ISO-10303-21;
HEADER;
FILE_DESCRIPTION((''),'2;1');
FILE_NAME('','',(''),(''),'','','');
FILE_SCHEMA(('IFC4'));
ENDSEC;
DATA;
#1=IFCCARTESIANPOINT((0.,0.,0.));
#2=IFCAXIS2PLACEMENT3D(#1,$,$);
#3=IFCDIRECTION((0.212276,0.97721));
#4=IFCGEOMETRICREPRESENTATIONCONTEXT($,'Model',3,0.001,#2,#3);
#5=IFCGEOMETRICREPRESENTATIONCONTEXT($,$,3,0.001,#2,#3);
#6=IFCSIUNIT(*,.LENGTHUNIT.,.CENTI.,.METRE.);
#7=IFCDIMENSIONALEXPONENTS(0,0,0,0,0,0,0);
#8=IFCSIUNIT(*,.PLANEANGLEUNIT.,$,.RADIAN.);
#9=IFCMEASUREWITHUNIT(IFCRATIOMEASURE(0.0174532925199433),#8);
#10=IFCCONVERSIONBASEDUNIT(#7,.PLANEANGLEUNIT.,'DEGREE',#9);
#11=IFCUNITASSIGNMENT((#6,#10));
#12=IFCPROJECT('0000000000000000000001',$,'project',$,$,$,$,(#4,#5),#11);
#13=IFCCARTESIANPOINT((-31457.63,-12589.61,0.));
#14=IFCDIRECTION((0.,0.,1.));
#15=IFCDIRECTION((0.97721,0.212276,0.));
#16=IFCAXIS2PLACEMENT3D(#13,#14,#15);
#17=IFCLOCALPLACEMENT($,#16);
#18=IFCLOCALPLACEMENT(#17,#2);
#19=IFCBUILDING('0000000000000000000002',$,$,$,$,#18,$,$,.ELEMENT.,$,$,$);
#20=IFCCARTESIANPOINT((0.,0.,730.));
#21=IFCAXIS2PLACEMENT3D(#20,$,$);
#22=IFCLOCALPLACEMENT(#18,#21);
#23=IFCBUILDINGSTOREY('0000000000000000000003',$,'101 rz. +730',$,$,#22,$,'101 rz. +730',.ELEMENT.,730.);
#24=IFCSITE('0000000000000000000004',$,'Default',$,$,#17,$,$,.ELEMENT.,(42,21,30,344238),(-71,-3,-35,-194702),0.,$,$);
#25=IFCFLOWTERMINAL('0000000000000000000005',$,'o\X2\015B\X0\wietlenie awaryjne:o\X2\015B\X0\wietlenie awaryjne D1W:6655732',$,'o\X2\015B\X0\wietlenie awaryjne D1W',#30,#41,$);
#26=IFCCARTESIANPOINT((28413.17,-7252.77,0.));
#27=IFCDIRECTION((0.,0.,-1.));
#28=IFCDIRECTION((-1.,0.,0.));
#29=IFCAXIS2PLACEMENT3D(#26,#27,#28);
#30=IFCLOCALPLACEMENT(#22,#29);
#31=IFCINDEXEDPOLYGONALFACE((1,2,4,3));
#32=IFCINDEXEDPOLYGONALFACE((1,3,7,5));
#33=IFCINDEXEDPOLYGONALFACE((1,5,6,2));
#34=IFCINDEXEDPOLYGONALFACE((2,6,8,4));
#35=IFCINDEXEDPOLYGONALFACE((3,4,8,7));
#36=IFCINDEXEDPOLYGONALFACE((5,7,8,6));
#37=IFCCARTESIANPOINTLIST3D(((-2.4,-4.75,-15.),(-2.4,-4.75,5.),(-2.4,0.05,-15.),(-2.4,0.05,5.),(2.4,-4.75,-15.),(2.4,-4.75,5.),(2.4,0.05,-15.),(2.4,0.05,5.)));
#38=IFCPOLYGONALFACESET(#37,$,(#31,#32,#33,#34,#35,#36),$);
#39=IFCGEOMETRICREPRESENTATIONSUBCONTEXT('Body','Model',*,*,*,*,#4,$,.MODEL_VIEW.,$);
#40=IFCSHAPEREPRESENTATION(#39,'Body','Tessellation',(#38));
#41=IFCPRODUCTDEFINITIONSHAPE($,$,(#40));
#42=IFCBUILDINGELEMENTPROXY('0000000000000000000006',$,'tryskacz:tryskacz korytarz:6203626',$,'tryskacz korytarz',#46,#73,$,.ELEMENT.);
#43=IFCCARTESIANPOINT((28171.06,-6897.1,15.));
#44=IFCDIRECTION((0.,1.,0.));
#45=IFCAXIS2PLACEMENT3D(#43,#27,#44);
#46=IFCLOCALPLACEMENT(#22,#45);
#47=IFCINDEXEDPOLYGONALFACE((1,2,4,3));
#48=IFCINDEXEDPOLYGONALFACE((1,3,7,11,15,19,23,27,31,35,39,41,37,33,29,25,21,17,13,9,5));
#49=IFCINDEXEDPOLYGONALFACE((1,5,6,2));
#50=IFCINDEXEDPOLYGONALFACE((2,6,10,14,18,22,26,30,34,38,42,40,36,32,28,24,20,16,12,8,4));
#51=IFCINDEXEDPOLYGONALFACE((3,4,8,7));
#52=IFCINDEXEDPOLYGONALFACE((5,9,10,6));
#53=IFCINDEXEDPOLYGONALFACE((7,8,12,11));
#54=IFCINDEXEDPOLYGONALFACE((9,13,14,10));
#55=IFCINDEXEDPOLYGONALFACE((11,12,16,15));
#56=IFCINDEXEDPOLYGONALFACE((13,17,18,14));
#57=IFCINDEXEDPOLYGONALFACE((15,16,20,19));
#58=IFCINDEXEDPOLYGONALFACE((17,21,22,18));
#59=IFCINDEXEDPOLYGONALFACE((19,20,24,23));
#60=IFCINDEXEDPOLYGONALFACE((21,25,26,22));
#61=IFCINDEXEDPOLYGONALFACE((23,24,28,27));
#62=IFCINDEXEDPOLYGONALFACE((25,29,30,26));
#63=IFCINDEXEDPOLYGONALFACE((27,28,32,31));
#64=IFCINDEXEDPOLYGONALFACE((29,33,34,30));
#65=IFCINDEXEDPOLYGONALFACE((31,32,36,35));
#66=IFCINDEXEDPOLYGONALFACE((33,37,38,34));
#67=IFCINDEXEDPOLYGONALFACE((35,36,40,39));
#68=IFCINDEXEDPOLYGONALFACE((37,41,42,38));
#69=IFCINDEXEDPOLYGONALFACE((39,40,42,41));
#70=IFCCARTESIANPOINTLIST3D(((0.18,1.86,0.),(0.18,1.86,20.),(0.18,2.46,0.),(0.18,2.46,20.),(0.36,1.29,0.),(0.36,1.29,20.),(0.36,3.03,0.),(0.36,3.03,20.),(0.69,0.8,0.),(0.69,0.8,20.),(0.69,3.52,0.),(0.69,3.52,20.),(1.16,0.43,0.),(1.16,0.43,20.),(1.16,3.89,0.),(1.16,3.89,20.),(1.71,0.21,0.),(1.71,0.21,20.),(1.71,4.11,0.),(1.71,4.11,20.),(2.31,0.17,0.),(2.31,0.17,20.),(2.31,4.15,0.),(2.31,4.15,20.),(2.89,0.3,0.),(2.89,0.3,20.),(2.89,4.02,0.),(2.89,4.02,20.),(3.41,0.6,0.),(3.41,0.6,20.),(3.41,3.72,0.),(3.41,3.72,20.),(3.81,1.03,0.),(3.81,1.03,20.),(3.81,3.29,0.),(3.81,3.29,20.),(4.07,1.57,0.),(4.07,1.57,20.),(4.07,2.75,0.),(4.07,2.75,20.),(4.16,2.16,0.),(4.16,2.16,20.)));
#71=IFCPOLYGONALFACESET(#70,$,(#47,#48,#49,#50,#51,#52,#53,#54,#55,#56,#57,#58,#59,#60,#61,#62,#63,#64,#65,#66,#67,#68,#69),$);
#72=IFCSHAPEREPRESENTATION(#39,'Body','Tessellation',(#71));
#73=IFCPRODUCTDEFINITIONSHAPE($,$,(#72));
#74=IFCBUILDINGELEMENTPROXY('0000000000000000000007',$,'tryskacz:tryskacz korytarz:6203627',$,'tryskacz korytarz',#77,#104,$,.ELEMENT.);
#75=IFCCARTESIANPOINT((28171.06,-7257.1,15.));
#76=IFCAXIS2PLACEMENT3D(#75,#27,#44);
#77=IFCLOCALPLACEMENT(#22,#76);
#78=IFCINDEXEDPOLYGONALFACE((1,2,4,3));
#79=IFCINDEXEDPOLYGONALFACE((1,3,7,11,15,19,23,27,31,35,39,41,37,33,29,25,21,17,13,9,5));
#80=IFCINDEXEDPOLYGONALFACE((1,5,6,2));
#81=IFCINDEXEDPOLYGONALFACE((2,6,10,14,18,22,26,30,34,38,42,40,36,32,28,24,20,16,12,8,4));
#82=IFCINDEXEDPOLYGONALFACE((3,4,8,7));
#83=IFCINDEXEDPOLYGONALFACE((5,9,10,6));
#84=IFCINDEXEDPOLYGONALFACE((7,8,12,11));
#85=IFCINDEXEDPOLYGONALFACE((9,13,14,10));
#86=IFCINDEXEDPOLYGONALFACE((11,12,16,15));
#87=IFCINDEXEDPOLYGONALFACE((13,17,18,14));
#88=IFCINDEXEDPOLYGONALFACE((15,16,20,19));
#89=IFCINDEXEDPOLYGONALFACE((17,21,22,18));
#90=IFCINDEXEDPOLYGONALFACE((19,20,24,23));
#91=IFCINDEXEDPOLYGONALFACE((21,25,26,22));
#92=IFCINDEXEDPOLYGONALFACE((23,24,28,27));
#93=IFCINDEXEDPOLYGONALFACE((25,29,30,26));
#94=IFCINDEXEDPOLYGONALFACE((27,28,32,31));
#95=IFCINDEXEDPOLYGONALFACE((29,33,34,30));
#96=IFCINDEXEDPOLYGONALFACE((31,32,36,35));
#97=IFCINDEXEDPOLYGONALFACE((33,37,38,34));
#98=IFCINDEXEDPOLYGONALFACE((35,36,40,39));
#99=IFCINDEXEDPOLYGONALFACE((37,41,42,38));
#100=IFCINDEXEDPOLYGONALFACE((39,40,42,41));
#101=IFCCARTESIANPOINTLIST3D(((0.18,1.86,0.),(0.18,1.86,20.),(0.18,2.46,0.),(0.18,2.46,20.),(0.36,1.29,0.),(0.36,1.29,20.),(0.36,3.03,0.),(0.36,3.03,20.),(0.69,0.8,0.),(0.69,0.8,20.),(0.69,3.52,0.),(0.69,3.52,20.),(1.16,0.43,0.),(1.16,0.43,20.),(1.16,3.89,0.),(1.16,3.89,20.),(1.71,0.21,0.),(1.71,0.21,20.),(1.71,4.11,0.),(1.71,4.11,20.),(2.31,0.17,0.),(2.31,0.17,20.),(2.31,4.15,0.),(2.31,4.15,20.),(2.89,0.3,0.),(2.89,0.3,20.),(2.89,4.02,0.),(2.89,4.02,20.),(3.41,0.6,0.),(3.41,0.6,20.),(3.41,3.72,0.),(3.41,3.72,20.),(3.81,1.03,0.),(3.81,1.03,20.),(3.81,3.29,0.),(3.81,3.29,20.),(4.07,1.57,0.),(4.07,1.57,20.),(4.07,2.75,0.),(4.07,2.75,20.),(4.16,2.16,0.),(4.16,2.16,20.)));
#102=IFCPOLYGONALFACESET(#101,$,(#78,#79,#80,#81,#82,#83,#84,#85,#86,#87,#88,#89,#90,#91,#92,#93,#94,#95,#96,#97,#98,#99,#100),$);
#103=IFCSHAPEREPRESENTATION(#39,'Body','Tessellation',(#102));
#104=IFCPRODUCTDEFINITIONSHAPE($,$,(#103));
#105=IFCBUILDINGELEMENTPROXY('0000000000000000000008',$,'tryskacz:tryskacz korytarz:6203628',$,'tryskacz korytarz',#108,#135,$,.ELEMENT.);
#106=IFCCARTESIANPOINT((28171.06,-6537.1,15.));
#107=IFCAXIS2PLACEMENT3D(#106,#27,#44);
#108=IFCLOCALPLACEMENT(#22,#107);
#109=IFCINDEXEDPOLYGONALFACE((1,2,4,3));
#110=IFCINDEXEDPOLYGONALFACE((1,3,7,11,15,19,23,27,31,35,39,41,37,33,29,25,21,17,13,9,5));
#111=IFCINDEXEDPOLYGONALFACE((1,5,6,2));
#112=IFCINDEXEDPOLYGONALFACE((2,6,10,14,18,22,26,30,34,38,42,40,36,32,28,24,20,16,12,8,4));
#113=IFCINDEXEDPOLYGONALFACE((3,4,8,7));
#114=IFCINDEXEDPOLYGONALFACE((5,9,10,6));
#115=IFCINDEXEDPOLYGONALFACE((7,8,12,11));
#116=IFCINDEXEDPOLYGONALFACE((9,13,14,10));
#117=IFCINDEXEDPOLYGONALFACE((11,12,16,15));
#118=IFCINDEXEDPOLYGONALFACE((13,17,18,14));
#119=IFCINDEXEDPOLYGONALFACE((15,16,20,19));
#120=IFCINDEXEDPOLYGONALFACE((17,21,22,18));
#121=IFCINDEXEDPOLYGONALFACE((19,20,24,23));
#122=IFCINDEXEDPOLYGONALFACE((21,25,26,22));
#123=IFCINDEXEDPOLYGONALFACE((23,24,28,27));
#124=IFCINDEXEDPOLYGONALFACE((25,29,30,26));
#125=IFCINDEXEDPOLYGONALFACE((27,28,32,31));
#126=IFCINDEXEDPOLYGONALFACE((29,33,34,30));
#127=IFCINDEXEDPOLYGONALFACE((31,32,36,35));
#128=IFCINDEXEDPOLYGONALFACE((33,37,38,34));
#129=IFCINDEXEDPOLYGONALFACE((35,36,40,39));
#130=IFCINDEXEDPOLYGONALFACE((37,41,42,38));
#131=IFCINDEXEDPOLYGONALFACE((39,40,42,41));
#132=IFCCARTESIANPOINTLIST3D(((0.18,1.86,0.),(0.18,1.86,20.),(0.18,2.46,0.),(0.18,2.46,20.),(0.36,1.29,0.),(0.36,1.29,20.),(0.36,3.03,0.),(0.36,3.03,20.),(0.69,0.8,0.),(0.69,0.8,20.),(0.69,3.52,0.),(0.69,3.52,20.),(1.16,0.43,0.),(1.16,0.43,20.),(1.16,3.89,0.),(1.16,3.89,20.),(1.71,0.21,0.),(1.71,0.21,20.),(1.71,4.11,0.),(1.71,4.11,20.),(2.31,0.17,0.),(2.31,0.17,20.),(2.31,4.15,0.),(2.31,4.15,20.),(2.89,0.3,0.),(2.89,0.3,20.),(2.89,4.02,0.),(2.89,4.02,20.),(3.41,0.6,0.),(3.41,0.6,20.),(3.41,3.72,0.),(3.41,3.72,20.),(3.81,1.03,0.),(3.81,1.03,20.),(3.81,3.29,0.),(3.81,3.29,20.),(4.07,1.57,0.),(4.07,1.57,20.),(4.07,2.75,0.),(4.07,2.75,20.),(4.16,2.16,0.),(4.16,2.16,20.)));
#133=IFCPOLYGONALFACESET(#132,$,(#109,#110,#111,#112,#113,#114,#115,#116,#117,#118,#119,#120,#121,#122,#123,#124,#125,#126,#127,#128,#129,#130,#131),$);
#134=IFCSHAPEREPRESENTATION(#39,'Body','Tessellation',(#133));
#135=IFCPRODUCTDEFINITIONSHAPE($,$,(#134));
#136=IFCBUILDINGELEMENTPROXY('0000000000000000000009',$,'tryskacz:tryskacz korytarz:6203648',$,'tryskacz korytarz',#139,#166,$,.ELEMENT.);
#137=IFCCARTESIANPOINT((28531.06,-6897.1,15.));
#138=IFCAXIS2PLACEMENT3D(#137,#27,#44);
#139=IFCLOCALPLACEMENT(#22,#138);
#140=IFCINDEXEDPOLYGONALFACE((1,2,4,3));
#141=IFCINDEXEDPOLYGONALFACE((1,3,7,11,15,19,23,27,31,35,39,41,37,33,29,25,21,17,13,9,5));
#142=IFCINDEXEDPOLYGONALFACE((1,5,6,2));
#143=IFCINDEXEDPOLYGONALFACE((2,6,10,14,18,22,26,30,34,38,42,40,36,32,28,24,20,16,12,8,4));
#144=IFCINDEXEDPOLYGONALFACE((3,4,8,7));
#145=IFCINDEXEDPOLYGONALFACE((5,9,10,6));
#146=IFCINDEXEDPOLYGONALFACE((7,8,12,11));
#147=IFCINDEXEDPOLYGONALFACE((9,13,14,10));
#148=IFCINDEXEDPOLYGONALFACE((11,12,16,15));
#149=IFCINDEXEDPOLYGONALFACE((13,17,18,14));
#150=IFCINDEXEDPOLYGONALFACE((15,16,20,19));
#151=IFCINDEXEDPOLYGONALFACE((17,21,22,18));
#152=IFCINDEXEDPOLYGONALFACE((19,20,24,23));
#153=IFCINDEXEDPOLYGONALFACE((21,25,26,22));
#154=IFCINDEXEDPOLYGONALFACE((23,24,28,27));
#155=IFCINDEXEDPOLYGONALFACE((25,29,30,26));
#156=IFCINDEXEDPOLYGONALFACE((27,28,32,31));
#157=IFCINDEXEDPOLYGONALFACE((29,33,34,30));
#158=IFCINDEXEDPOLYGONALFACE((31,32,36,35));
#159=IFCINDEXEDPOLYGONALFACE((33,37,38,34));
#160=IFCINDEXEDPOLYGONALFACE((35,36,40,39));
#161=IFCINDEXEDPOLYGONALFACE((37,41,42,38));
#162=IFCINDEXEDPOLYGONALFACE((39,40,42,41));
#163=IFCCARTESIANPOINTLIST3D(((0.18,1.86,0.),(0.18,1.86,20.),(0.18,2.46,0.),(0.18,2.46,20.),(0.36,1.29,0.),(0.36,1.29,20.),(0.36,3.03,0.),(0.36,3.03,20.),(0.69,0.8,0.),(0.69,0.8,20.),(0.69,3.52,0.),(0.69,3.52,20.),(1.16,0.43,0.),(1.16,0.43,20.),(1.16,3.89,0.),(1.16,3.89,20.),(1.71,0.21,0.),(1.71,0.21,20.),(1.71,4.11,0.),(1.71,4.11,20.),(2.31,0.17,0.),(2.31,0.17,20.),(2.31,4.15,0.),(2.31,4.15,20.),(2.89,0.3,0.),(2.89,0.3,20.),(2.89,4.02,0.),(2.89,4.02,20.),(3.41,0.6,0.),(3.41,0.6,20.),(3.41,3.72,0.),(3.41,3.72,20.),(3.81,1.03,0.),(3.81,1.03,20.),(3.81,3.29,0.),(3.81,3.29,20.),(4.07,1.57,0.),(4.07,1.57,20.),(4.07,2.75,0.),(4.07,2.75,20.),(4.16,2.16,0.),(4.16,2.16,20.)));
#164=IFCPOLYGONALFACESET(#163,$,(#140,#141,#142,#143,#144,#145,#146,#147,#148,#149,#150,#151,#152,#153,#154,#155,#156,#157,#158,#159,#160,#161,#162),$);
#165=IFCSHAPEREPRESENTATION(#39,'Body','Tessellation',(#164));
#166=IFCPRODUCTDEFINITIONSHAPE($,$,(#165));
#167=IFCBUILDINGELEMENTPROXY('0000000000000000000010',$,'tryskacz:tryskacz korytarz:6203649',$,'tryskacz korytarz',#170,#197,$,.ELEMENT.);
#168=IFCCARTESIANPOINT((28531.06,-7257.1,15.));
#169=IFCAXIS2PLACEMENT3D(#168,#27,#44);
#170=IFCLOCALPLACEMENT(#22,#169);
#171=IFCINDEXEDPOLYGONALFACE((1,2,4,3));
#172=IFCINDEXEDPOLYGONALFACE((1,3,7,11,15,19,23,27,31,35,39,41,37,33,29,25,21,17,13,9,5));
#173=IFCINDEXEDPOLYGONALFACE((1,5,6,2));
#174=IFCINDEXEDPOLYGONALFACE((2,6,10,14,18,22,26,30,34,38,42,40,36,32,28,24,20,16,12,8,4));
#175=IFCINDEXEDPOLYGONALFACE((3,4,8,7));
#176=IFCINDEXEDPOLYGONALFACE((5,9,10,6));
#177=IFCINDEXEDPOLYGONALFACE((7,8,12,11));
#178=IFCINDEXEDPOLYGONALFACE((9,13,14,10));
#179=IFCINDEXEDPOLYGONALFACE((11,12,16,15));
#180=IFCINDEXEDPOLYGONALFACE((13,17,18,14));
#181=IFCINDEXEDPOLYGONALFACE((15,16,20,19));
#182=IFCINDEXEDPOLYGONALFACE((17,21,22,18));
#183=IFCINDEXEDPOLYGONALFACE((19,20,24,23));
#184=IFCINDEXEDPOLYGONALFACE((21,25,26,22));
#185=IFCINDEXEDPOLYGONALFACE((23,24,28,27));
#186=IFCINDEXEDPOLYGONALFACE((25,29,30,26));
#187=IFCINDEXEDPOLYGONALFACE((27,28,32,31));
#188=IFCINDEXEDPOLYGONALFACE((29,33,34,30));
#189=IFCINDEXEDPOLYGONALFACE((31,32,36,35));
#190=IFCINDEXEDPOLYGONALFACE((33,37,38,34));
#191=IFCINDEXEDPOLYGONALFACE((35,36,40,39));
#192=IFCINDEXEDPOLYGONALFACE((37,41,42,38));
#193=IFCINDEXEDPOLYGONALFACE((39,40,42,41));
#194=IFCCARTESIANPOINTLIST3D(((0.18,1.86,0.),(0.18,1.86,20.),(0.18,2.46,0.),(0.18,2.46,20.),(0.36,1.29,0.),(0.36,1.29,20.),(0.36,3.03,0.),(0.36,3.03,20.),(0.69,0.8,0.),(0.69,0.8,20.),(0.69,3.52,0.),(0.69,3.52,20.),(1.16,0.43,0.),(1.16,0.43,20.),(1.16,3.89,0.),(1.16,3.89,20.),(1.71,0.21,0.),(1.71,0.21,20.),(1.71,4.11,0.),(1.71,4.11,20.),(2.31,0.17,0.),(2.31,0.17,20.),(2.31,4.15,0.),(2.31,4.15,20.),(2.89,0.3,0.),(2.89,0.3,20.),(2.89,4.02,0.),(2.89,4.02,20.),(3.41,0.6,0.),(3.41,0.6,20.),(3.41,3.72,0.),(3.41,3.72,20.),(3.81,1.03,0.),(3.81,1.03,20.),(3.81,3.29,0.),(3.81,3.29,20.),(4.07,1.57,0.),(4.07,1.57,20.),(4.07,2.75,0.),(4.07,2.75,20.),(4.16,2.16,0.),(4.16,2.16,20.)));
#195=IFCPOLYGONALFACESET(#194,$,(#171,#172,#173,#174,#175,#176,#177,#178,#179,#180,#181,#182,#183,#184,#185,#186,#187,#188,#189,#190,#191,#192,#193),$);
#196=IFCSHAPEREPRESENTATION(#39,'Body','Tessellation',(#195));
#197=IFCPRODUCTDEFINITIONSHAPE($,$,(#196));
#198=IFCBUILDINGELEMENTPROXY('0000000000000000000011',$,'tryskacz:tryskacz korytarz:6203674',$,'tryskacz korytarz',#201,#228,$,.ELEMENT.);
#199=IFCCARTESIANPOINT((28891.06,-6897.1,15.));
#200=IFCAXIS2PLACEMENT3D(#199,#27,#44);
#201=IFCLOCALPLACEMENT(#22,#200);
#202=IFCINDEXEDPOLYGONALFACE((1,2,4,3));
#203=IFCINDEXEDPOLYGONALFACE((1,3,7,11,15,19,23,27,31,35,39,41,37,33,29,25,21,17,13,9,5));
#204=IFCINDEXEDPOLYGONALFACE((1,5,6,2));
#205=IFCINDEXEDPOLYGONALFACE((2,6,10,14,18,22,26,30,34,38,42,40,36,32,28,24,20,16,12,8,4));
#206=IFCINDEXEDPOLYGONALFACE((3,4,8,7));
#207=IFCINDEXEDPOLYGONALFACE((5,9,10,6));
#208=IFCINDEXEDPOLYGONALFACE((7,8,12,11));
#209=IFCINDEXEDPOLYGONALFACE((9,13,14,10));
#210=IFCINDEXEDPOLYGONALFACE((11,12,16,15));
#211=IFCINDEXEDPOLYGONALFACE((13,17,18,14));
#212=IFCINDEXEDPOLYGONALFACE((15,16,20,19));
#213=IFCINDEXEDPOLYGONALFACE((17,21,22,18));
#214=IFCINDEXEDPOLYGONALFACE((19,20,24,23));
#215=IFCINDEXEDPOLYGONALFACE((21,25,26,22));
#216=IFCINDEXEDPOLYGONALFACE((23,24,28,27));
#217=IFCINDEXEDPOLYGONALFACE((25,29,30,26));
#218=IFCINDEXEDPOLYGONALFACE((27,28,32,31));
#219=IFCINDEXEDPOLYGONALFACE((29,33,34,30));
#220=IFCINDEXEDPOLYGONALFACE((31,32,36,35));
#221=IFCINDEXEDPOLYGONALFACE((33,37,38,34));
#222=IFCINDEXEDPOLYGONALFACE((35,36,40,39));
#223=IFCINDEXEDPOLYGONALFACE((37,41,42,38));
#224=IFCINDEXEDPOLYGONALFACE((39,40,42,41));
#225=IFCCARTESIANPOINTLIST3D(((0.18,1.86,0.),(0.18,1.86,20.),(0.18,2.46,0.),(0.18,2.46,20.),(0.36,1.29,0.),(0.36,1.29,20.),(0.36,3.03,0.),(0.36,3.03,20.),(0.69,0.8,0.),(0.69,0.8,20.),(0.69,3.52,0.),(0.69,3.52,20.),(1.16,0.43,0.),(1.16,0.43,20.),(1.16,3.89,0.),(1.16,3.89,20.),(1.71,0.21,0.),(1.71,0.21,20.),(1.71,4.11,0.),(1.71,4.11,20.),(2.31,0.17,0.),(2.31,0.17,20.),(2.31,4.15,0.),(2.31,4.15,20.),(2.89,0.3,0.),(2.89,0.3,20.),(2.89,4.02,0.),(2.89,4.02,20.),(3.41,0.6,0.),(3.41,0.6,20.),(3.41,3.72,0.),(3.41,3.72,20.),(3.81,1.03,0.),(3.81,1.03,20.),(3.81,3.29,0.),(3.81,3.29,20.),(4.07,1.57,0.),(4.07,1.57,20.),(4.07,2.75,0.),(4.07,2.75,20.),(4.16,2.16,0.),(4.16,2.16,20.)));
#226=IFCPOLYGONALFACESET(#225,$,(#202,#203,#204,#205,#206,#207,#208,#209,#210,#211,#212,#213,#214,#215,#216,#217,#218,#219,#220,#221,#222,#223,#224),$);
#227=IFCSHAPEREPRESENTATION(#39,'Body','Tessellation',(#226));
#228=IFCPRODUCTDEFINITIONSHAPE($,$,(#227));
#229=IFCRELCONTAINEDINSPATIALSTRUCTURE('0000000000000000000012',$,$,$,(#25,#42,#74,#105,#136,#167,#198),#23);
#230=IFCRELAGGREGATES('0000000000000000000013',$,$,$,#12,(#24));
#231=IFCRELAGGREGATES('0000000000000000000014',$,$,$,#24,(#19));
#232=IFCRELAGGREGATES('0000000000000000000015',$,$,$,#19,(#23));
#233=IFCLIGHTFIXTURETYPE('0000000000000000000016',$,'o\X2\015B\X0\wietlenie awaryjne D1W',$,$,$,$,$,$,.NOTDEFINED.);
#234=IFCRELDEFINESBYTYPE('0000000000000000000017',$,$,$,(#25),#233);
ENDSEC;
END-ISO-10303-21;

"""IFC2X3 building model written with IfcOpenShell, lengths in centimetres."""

from ifc_helpers import new_model, entity, si_unit, converted_unit, direction, frame, frame_2d, origin, place, context, subcontext, project, spatial, rectangle, circle, extrude, source, transform, mapped, type_object, type_shapes, element, save


model = new_model("IFC2X3")

# Units and contexts
model_context = context("Model", 3, precision=0.001, world=origin(), true_north=direction((0.212276, 0.97721)))
context_of_model = context(None, 3, precision=0.001, world=origin(), true_north=direction((0.212276, 0.97721)))
body_context = subcontext(model_context, "Body", "Model", "MODEL_VIEW")
ifc_project = project(units=[si_unit("LENGTHUNIT", "METRE", prefix="CENTI"), converted_unit("PLANEANGLEUNIT", "DEGREE", entity("IfcRatioMeasure", 0.0174532925199433), si_unit("PLANEANGLEUNIT", "RADIAN"), dimensions=[0, 0, 0, 0, 0, 0, 0])], contexts=[model_context, context_of_model])

# Site, building, storey
site_placement = place(None, frame((-31457.63, -12589.61, 0.0), z_axis=(0.0, 0.0, 1.0), x_axis=(0.97721, 0.212276, 0.0)))
site = spatial("IfcSite", under=ifc_project, at=site_placement, Name="Default", CompositionType="ELEMENT", RefLatitude=(42, 21, 30, 344238), RefLongitude=(-71, -3, -35, -194702), RefElevation=0.0)
building_placement = place(site_placement, origin())
building = spatial("IfcBuilding", under=site, at=building_placement, CompositionType="ELEMENT")
storey_placement = place(building_placement, frame((0.0, 0.0, 730.0)))
storey = spatial("IfcBuildingStorey", under=building, at=storey_placement, Name="101 rz. +730", LongName="101 rz. +730", CompositionType="ELEMENT", Elevation=730.0)

# Flow terminal
light_fixture_type_1 = type_object("IfcLightFixtureType", Name="oświetlenie awaryjne D1W", PredefinedType="NOTDEFINED")
shared_shape_1 = source(origin(), body_context, "Body", "SweptSolid", [
    extrude(rectangle(XDim=4.8, YDim=4.8, at=frame_2d((0.0, 0.0), x_axis=(1.0, 0.0))), frame((0.0, -2.35, -15.0), z_axis=(0.0, 0.0, 1.0), x_axis=(0.0, -1.0, 0.0)), (0.0, 0.0, 1.0), 20.0),
])
type_shapes(light_fixture_type_1, [shared_shape_1])
flow_terminal_placement = place(storey_placement, frame((28413.17, -7252.77, 0.0), z_axis=(0.0, 0.0, -1.0), x_axis=(-1.0, 0.0, 0.0)))
element("IfcFlowTerminal", 1, at=flow_terminal_placement, inside=storey, type_object=light_fixture_type_1, Name="oświetlenie awaryjne:oświetlenie awaryjne D1W:6655732", ObjectType="oświetlenie awaryjne D1W", context=body_context, shape_type="MappedRepresentation", body=[
    mapped(shared_shape_1, transform((0.0, 0.0, 0.0), scale=1.0)),
])

# Building element proxies
shared_shape_2 = source(origin(), body_context, "Body", "SweptSolid", [
    extrude(circle(Radius=2.0, at=frame_2d((0.0, 0.0), x_axis=(1.0, 0.0))), frame((2.16, 2.16, 0.0)), (0.0, 0.0, 1.0), 20.0),
])
for number, where, z_axis, x_axis, name in (
    (2, (28171.06, -6897.1, 15.0), (0.0, 0.0, -1.0), (0.0, 1.0, 0.0), "tryskacz:tryskacz korytarz:6203626"),
    (3, (28171.06, -7257.1, 15.0), (0.0, 0.0, -1.0), (0.0, 1.0, 0.0), "tryskacz:tryskacz korytarz:6203627"),
    (4, (28171.06, -6537.1, 15.0), (0.0, 0.0, -1.0), (0.0, 1.0, 0.0), "tryskacz:tryskacz korytarz:6203628"),
    (5, (28531.06, -6897.1, 15.0), (0.0, 0.0, -1.0), (0.0, 1.0, 0.0), "tryskacz:tryskacz korytarz:6203648"),
    (6, (28531.06, -7257.1, 15.0), (0.0, 0.0, -1.0), (0.0, 1.0, 0.0), "tryskacz:tryskacz korytarz:6203649"),
    (7, (28891.06, -6897.1, 15.0), (0.0, 0.0, -1.0), (0.0, 1.0, 0.0), "tryskacz:tryskacz korytarz:6203674"),
):
    element("IfcBuildingElementProxy", number, at=place(storey_placement, frame(where, z_axis=z_axis, x_axis=x_axis)), inside=storey, Name=name, ObjectType="tryskacz korytarz", CompositionType="ELEMENT", context=body_context, shape_type="MappedRepresentation", body=[
        mapped(shared_shape_2, transform((0.0, 0.0, 0.0), scale=1.0)),
    ])

save(model, "model.ifc")
